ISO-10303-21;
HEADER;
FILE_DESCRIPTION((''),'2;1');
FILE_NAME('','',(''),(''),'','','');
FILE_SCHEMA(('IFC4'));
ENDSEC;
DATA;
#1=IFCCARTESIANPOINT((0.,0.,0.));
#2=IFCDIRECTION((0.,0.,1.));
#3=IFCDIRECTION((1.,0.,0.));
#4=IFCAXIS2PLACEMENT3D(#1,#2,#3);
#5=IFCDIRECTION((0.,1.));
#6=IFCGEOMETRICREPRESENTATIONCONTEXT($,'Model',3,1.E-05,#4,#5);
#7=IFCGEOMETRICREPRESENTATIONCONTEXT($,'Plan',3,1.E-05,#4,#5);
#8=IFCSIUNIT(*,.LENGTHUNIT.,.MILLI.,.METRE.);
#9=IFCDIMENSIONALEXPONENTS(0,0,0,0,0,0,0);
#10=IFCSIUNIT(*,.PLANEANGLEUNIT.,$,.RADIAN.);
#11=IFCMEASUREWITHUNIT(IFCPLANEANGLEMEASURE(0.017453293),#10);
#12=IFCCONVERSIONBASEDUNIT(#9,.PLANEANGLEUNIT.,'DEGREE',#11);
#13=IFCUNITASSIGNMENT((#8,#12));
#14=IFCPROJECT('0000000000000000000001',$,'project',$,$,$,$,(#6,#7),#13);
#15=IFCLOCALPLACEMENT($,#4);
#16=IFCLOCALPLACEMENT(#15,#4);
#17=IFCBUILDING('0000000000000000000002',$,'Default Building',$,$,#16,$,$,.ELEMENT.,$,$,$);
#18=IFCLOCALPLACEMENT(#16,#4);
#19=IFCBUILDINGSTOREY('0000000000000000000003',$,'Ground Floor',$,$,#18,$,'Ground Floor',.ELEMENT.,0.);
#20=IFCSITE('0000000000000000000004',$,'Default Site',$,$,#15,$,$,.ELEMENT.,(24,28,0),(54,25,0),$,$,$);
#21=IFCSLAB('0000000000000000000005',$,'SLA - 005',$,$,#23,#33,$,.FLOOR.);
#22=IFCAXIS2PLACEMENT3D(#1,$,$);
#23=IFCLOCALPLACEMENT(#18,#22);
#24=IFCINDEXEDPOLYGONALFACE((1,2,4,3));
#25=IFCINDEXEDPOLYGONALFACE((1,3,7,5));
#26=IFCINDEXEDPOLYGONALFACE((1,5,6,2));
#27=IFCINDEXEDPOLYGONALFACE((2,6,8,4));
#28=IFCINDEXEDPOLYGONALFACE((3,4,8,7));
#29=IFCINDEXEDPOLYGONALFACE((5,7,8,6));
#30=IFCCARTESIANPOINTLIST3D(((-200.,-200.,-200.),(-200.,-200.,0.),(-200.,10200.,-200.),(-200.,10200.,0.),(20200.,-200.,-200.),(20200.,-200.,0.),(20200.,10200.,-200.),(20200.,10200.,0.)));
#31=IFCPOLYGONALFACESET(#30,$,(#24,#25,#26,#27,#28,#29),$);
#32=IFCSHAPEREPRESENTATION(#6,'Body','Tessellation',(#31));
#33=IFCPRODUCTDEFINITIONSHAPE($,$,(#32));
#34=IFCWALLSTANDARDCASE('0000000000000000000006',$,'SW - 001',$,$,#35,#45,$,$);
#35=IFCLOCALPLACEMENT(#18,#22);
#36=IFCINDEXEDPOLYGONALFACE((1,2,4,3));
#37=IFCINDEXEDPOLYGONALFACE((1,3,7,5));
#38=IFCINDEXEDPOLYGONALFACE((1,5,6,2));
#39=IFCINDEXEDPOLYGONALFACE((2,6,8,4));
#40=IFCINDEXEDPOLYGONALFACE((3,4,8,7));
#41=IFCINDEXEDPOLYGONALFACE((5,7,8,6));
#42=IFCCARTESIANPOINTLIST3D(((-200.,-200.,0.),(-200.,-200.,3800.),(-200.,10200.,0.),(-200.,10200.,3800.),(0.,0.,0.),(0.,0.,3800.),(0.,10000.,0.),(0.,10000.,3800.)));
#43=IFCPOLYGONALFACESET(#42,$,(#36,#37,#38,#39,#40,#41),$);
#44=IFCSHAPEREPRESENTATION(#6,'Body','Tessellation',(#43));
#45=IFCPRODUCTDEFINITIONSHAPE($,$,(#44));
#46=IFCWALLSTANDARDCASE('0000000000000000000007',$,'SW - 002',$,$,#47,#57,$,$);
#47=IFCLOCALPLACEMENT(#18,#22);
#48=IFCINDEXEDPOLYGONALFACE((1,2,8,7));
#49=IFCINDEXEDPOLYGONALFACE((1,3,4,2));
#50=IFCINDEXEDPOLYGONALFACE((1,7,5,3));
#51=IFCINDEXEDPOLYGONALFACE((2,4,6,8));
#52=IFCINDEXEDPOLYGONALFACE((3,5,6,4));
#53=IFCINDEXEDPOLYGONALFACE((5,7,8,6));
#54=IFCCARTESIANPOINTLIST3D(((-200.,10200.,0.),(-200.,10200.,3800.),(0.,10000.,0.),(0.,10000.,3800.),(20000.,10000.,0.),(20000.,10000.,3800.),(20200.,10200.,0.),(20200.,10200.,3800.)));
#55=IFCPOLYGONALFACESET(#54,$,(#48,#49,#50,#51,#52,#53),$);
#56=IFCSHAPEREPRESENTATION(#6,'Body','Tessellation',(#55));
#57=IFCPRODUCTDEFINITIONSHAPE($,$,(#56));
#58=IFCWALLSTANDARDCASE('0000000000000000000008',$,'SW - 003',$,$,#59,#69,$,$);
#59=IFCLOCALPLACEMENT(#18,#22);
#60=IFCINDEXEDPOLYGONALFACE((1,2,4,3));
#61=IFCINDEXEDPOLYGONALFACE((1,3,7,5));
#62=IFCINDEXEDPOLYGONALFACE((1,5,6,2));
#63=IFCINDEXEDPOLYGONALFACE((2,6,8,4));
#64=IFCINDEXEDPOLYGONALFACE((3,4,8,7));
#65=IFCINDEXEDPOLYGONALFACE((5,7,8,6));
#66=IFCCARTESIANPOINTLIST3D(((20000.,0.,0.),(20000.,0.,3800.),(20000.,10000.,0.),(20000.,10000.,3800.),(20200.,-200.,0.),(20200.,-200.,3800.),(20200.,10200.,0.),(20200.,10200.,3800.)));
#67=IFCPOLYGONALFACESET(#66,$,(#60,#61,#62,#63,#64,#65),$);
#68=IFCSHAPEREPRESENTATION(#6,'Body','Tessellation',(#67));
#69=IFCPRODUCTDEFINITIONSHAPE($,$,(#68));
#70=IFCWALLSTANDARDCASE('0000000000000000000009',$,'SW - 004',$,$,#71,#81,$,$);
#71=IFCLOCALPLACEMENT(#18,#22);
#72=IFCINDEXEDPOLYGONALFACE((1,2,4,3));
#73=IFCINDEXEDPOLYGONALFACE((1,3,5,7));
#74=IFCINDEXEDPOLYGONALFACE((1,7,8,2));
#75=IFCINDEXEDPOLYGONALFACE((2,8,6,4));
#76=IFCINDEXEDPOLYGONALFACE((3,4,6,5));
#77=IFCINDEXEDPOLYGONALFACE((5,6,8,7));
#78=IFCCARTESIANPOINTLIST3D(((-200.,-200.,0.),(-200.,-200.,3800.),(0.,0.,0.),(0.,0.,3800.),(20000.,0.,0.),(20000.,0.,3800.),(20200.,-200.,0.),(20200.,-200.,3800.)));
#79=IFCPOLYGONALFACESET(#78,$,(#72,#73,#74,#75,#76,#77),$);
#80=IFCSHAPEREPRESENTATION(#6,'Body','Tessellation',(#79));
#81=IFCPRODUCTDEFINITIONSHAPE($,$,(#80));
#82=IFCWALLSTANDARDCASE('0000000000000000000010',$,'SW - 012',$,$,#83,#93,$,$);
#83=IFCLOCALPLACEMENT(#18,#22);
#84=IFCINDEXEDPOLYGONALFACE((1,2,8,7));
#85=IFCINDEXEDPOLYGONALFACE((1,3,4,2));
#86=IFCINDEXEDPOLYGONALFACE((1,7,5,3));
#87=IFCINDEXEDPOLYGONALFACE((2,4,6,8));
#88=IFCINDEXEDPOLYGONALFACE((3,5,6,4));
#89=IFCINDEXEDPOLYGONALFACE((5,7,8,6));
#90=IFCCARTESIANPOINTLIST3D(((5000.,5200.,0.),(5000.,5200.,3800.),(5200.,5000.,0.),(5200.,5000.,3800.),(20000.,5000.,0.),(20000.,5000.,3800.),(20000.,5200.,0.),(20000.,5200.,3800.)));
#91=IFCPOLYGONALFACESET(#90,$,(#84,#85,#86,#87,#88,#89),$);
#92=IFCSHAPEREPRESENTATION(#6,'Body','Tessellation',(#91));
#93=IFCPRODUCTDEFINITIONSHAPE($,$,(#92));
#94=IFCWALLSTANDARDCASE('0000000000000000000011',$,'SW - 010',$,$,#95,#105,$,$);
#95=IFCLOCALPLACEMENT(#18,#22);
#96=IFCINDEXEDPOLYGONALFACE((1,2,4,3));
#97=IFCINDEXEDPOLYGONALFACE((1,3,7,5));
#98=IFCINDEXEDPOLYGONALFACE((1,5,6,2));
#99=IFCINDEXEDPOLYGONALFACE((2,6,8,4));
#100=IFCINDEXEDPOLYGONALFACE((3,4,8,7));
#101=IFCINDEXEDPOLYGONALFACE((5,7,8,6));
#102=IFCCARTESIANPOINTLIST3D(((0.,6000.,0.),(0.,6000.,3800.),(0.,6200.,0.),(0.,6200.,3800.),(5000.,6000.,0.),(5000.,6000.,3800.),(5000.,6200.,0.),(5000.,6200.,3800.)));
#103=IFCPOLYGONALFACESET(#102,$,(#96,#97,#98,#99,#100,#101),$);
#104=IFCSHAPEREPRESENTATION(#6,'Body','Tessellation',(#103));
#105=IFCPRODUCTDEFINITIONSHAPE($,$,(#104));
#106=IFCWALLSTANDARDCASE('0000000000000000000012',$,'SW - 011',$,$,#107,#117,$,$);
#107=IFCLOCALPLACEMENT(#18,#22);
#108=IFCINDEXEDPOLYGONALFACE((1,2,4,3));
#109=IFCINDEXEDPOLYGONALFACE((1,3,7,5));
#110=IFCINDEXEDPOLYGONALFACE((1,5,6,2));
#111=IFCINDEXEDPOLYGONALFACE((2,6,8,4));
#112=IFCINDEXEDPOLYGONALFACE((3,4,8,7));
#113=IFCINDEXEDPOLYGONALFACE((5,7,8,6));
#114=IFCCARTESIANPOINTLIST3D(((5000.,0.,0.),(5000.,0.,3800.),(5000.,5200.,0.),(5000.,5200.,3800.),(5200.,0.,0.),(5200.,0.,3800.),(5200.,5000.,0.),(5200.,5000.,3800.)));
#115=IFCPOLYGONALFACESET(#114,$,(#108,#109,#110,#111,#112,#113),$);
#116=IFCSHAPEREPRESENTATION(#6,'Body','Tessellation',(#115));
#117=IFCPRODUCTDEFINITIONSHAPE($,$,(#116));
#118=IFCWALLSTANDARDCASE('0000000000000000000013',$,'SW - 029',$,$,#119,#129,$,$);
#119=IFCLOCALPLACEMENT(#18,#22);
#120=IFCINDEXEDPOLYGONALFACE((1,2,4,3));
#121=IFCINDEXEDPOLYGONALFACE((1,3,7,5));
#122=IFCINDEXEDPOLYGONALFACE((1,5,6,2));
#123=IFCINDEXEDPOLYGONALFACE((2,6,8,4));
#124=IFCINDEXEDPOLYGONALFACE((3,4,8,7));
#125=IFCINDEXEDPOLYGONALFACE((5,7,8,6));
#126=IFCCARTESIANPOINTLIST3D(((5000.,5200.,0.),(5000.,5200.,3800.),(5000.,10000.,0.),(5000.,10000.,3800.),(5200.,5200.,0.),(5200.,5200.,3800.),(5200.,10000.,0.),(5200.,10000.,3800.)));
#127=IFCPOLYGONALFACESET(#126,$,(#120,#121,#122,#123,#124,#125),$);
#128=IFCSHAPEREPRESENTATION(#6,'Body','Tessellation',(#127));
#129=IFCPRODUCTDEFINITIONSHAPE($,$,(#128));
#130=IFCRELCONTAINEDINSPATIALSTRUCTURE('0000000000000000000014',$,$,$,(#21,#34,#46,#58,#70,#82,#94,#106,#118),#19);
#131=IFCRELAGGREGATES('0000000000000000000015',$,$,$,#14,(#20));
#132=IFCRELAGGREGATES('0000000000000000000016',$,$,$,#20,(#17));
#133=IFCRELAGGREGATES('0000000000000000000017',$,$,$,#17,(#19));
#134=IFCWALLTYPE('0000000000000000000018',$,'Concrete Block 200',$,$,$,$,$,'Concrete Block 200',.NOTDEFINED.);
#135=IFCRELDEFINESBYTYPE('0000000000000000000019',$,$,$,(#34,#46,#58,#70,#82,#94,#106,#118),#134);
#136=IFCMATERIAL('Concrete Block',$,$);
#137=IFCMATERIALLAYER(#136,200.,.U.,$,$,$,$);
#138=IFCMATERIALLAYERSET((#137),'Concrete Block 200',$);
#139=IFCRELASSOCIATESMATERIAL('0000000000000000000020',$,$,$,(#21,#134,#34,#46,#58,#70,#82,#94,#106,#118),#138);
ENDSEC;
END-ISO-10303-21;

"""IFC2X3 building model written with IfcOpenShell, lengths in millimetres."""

from ifc_helpers import new_model, entity, si_unit, converted_unit, direction, frame, origin_with_axes, place, context, project, spatial, polyline, outline, extrude, material, layer, layer_set, layer_usage, type_object, element, save


model = new_model("IFC2X3")

# Units and contexts
model_context = context("Model", 3, precision=1e-05, world=origin_with_axes(), true_north=direction((0.0, 1.0)))
plan_context = context("Plan", 3, precision=1e-05, world=origin_with_axes(), true_north=direction((0.0, 1.0)))
ifc_project = project(units=[si_unit("LENGTHUNIT", "METRE", prefix="MILLI"), converted_unit("PLANEANGLEUNIT", "DEGREE", entity("IfcPlaneAngleMeasure", 0.017453293), si_unit("PLANEANGLEUNIT", "RADIAN"), dimensions=[0, 0, 0, 0, 0, 0, 0])], contexts=[model_context, plan_context])

# Site, building, storey
site_placement = place(None, origin_with_axes())
site = spatial("IfcSite", under=ifc_project, at=site_placement, Name="Default Site", CompositionType="ELEMENT", RefLatitude=(24, 28, 0), RefLongitude=(54, 25, 0))
building_placement = place(site_placement, origin_with_axes())
building = spatial("IfcBuilding", under=site, at=building_placement, Name="Default Building", CompositionType="ELEMENT")
storey_placement = place(building_placement, origin_with_axes())
storey = spatial("IfcBuildingStorey", under=building, at=storey_placement, Name="Ground Floor", LongName="Ground Floor", CompositionType="ELEMENT", Elevation=0.0)

# Slab
ifc_material = material(Name="Concrete Block")
ifc_layer = layer(ifc_material, 200.0, ventilated="UNKNOWN")
ifc_layer_set = layer_set([ifc_layer], Name="Concrete Block 200")
ifc_layer_usage_1 = layer_usage(ifc_layer_set, "AXIS3", "NEGATIVE", 200.0)
slab_placement = place(storey_placement, frame((-200.0, 10200.0, -200.0), z_axis=(0.0, 0.0, 1.0), x_axis=(1.0, 0.0, 0.0)))
element("IfcSlab", 1, at=slab_placement, inside=storey, material=ifc_layer_usage_1, Name="SLA - 005", PredefinedType="FLOOR", context=model_context, shape_type="SweptSolid", body=[
    extrude(outline(polyline([(0.0, 0.0), (20400.0, 0.0), (20400.0, -10400.0), (0.0, -10400.0), (0.0, 0.0)])), origin_with_axes(), (0.0, 0.0, 1.0), 200.0),
])

# Walls
ifc_layer_usage_2 = layer_usage(ifc_layer_set, "AXIS2", "POSITIVE", 0.0)
wall_type = type_object("IfcWallType", Name="Concrete Block 200", ElementType="Concrete Block 200", PredefinedType="NOTDEFINED", material=ifc_layer_set)
wall_1_placement = place(storey_placement, frame((0.0, 0.0, 0.0), z_axis=(0.0, 0.0, 1.0), x_axis=(0.0, 1.0, 0.0)))
element("IfcWallStandardCase", 2, at=wall_1_placement, inside=storey, type_object=wall_type, material=ifc_layer_usage_2, Name="SW - 001", context=model_context, shape_type="SweptSolid", body=[
    extrude(outline(polyline([(0.0, 0.0), (10000.0, 0.0), (10200.0, 200.0), (-200.0, 200.0), (0.0, 0.0)])), origin_with_axes(), (0.0, 0.0, 1.0), 3800.0),
])
ifc_layer_usage_3 = layer_usage(ifc_layer_set, "AXIS2", "POSITIVE", 0.0)
wall_2_placement = place(storey_placement, frame((0.0, 10000.0, 0.0), z_axis=(0.0, 0.0, 1.0), x_axis=(1.0, 0.0, 0.0)))
element("IfcWallStandardCase", 3, at=wall_2_placement, inside=storey, type_object=wall_type, material=ifc_layer_usage_3, Name="SW - 002", context=model_context, shape_type="SweptSolid", body=[
    extrude(outline(polyline([(0.0, 0.0), (20000.0, 0.0), (20200.0, 200.0), (-200.0, 200.0), (0.0, 0.0)])), origin_with_axes(), (0.0, 0.0, 1.0), 3800.0),
])
ifc_layer_usage_4 = layer_usage(ifc_layer_set, "AXIS2", "POSITIVE", 0.0)
wall_3_placement = place(storey_placement, frame((20000.0, 10000.0, 0.0), z_axis=(0.0, 0.0, 1.0), x_axis=(0.0, -1.0, 0.0)))
element("IfcWallStandardCase", 4, at=wall_3_placement, inside=storey, type_object=wall_type, material=ifc_layer_usage_4, Name="SW - 003", context=model_context, shape_type="SweptSolid", body=[
    extrude(outline(polyline([(0.0, 0.0), (10000.0, 0.0), (10200.0, 200.0), (-200.0, 200.0), (0.0, 0.0)])), origin_with_axes(), (0.0, 0.0, 1.0), 3800.0),
])
ifc_layer_usage_5 = layer_usage(ifc_layer_set, "AXIS2", "POSITIVE", 0.0)
wall_4_placement = place(storey_placement, frame((20000.0, 0.0, 0.0), z_axis=(0.0, 0.0, 1.0), x_axis=(-1.0, 0.0, 0.0)))
element("IfcWallStandardCase", 5, at=wall_4_placement, inside=storey, type_object=wall_type, material=ifc_layer_usage_5, Name="SW - 004", context=model_context, shape_type="SweptSolid", body=[
    extrude(outline(polyline([(0.0, 0.0), (20000.0, 0.0), (20200.0, 200.0), (-200.0, 200.0), (0.0, 0.0)])), origin_with_axes(), (0.0, 0.0, 1.0), 3800.0),
])
ifc_layer_usage_6 = layer_usage(ifc_layer_set, "AXIS2", "POSITIVE", 0.0)
wall_5_placement = place(storey_placement, frame((5000.0, 5000.0, 0.0), z_axis=(0.0, 0.0, 1.0), x_axis=(1.0, 0.0, 0.0)))
element("IfcWallStandardCase", 6, at=wall_5_placement, inside=storey, type_object=wall_type, material=ifc_layer_usage_6, Name="SW - 012", context=model_context, shape_type="SweptSolid", body=[
    extrude(outline(polyline([(200.0, 0.0), (15000.0, 0.0), (15000.0, 200.0), (0.0, 200.0), (200.0, 0.0)])), origin_with_axes(), (0.0, 0.0, 1.0), 3800.0),
])
ifc_layer_usage_7 = layer_usage(ifc_layer_set, "AXIS2", "POSITIVE", 0.0)
wall_6_placement = place(storey_placement, frame((0.0, 6000.0, 0.0), z_axis=(0.0, 0.0, 1.0), x_axis=(1.0, 0.0, 0.0)))
element("IfcWallStandardCase", 7, at=wall_6_placement, inside=storey, type_object=wall_type, material=ifc_layer_usage_7, Name="SW - 010", context=model_context, shape_type="SweptSolid", body=[
    extrude(outline(polyline([(0.0, 0.0), (5000.0, 0.0), (5000.0, 200.0), (0.0, 200.0), (0.0, 0.0)])), origin_with_axes(), (0.0, 0.0, 1.0), 3800.0),
])
ifc_layer_usage_8 = layer_usage(ifc_layer_set, "AXIS2", "POSITIVE", 0.0)
wall_7_placement = place(storey_placement, frame((5000.0, 5000.0, 0.0), z_axis=(0.0, 0.0, 1.0), x_axis=(0.0, -1.0, 0.0)))
element("IfcWallStandardCase", 8, at=wall_7_placement, inside=storey, type_object=wall_type, material=ifc_layer_usage_8, Name="SW - 011", context=model_context, shape_type="SweptSolid", body=[
    extrude(outline(polyline([(-200.0, 0.0), (5000.0, 0.0), (5000.0, 200.0), (0.0, 200.0), (-200.0, 0.0)])), origin_with_axes(), (0.0, 0.0, 1.0), 3800.0),
])
ifc_layer_usage_9 = layer_usage(ifc_layer_set, "AXIS2", "NEGATIVE", 0.0)
wall_8_placement = place(storey_placement, frame((5200.0, 10000.0, 0.0), z_axis=(0.0, 0.0, 1.0), x_axis=(0.0, -1.0, 0.0)))
element("IfcWallStandardCase", 9, at=wall_8_placement, inside=storey, type_object=wall_type, material=ifc_layer_usage_9, Name="SW - 029", context=model_context, shape_type="SweptSolid", body=[
    extrude(outline(polyline([(0.0, -200.0), (4800.0, -200.0), (4800.0, 0.0), (0.0, 0.0), (0.0, -200.0)])), origin_with_axes(), (0.0, 0.0, 1.0), 3800.0),
])

save(model, "model.ifc")
